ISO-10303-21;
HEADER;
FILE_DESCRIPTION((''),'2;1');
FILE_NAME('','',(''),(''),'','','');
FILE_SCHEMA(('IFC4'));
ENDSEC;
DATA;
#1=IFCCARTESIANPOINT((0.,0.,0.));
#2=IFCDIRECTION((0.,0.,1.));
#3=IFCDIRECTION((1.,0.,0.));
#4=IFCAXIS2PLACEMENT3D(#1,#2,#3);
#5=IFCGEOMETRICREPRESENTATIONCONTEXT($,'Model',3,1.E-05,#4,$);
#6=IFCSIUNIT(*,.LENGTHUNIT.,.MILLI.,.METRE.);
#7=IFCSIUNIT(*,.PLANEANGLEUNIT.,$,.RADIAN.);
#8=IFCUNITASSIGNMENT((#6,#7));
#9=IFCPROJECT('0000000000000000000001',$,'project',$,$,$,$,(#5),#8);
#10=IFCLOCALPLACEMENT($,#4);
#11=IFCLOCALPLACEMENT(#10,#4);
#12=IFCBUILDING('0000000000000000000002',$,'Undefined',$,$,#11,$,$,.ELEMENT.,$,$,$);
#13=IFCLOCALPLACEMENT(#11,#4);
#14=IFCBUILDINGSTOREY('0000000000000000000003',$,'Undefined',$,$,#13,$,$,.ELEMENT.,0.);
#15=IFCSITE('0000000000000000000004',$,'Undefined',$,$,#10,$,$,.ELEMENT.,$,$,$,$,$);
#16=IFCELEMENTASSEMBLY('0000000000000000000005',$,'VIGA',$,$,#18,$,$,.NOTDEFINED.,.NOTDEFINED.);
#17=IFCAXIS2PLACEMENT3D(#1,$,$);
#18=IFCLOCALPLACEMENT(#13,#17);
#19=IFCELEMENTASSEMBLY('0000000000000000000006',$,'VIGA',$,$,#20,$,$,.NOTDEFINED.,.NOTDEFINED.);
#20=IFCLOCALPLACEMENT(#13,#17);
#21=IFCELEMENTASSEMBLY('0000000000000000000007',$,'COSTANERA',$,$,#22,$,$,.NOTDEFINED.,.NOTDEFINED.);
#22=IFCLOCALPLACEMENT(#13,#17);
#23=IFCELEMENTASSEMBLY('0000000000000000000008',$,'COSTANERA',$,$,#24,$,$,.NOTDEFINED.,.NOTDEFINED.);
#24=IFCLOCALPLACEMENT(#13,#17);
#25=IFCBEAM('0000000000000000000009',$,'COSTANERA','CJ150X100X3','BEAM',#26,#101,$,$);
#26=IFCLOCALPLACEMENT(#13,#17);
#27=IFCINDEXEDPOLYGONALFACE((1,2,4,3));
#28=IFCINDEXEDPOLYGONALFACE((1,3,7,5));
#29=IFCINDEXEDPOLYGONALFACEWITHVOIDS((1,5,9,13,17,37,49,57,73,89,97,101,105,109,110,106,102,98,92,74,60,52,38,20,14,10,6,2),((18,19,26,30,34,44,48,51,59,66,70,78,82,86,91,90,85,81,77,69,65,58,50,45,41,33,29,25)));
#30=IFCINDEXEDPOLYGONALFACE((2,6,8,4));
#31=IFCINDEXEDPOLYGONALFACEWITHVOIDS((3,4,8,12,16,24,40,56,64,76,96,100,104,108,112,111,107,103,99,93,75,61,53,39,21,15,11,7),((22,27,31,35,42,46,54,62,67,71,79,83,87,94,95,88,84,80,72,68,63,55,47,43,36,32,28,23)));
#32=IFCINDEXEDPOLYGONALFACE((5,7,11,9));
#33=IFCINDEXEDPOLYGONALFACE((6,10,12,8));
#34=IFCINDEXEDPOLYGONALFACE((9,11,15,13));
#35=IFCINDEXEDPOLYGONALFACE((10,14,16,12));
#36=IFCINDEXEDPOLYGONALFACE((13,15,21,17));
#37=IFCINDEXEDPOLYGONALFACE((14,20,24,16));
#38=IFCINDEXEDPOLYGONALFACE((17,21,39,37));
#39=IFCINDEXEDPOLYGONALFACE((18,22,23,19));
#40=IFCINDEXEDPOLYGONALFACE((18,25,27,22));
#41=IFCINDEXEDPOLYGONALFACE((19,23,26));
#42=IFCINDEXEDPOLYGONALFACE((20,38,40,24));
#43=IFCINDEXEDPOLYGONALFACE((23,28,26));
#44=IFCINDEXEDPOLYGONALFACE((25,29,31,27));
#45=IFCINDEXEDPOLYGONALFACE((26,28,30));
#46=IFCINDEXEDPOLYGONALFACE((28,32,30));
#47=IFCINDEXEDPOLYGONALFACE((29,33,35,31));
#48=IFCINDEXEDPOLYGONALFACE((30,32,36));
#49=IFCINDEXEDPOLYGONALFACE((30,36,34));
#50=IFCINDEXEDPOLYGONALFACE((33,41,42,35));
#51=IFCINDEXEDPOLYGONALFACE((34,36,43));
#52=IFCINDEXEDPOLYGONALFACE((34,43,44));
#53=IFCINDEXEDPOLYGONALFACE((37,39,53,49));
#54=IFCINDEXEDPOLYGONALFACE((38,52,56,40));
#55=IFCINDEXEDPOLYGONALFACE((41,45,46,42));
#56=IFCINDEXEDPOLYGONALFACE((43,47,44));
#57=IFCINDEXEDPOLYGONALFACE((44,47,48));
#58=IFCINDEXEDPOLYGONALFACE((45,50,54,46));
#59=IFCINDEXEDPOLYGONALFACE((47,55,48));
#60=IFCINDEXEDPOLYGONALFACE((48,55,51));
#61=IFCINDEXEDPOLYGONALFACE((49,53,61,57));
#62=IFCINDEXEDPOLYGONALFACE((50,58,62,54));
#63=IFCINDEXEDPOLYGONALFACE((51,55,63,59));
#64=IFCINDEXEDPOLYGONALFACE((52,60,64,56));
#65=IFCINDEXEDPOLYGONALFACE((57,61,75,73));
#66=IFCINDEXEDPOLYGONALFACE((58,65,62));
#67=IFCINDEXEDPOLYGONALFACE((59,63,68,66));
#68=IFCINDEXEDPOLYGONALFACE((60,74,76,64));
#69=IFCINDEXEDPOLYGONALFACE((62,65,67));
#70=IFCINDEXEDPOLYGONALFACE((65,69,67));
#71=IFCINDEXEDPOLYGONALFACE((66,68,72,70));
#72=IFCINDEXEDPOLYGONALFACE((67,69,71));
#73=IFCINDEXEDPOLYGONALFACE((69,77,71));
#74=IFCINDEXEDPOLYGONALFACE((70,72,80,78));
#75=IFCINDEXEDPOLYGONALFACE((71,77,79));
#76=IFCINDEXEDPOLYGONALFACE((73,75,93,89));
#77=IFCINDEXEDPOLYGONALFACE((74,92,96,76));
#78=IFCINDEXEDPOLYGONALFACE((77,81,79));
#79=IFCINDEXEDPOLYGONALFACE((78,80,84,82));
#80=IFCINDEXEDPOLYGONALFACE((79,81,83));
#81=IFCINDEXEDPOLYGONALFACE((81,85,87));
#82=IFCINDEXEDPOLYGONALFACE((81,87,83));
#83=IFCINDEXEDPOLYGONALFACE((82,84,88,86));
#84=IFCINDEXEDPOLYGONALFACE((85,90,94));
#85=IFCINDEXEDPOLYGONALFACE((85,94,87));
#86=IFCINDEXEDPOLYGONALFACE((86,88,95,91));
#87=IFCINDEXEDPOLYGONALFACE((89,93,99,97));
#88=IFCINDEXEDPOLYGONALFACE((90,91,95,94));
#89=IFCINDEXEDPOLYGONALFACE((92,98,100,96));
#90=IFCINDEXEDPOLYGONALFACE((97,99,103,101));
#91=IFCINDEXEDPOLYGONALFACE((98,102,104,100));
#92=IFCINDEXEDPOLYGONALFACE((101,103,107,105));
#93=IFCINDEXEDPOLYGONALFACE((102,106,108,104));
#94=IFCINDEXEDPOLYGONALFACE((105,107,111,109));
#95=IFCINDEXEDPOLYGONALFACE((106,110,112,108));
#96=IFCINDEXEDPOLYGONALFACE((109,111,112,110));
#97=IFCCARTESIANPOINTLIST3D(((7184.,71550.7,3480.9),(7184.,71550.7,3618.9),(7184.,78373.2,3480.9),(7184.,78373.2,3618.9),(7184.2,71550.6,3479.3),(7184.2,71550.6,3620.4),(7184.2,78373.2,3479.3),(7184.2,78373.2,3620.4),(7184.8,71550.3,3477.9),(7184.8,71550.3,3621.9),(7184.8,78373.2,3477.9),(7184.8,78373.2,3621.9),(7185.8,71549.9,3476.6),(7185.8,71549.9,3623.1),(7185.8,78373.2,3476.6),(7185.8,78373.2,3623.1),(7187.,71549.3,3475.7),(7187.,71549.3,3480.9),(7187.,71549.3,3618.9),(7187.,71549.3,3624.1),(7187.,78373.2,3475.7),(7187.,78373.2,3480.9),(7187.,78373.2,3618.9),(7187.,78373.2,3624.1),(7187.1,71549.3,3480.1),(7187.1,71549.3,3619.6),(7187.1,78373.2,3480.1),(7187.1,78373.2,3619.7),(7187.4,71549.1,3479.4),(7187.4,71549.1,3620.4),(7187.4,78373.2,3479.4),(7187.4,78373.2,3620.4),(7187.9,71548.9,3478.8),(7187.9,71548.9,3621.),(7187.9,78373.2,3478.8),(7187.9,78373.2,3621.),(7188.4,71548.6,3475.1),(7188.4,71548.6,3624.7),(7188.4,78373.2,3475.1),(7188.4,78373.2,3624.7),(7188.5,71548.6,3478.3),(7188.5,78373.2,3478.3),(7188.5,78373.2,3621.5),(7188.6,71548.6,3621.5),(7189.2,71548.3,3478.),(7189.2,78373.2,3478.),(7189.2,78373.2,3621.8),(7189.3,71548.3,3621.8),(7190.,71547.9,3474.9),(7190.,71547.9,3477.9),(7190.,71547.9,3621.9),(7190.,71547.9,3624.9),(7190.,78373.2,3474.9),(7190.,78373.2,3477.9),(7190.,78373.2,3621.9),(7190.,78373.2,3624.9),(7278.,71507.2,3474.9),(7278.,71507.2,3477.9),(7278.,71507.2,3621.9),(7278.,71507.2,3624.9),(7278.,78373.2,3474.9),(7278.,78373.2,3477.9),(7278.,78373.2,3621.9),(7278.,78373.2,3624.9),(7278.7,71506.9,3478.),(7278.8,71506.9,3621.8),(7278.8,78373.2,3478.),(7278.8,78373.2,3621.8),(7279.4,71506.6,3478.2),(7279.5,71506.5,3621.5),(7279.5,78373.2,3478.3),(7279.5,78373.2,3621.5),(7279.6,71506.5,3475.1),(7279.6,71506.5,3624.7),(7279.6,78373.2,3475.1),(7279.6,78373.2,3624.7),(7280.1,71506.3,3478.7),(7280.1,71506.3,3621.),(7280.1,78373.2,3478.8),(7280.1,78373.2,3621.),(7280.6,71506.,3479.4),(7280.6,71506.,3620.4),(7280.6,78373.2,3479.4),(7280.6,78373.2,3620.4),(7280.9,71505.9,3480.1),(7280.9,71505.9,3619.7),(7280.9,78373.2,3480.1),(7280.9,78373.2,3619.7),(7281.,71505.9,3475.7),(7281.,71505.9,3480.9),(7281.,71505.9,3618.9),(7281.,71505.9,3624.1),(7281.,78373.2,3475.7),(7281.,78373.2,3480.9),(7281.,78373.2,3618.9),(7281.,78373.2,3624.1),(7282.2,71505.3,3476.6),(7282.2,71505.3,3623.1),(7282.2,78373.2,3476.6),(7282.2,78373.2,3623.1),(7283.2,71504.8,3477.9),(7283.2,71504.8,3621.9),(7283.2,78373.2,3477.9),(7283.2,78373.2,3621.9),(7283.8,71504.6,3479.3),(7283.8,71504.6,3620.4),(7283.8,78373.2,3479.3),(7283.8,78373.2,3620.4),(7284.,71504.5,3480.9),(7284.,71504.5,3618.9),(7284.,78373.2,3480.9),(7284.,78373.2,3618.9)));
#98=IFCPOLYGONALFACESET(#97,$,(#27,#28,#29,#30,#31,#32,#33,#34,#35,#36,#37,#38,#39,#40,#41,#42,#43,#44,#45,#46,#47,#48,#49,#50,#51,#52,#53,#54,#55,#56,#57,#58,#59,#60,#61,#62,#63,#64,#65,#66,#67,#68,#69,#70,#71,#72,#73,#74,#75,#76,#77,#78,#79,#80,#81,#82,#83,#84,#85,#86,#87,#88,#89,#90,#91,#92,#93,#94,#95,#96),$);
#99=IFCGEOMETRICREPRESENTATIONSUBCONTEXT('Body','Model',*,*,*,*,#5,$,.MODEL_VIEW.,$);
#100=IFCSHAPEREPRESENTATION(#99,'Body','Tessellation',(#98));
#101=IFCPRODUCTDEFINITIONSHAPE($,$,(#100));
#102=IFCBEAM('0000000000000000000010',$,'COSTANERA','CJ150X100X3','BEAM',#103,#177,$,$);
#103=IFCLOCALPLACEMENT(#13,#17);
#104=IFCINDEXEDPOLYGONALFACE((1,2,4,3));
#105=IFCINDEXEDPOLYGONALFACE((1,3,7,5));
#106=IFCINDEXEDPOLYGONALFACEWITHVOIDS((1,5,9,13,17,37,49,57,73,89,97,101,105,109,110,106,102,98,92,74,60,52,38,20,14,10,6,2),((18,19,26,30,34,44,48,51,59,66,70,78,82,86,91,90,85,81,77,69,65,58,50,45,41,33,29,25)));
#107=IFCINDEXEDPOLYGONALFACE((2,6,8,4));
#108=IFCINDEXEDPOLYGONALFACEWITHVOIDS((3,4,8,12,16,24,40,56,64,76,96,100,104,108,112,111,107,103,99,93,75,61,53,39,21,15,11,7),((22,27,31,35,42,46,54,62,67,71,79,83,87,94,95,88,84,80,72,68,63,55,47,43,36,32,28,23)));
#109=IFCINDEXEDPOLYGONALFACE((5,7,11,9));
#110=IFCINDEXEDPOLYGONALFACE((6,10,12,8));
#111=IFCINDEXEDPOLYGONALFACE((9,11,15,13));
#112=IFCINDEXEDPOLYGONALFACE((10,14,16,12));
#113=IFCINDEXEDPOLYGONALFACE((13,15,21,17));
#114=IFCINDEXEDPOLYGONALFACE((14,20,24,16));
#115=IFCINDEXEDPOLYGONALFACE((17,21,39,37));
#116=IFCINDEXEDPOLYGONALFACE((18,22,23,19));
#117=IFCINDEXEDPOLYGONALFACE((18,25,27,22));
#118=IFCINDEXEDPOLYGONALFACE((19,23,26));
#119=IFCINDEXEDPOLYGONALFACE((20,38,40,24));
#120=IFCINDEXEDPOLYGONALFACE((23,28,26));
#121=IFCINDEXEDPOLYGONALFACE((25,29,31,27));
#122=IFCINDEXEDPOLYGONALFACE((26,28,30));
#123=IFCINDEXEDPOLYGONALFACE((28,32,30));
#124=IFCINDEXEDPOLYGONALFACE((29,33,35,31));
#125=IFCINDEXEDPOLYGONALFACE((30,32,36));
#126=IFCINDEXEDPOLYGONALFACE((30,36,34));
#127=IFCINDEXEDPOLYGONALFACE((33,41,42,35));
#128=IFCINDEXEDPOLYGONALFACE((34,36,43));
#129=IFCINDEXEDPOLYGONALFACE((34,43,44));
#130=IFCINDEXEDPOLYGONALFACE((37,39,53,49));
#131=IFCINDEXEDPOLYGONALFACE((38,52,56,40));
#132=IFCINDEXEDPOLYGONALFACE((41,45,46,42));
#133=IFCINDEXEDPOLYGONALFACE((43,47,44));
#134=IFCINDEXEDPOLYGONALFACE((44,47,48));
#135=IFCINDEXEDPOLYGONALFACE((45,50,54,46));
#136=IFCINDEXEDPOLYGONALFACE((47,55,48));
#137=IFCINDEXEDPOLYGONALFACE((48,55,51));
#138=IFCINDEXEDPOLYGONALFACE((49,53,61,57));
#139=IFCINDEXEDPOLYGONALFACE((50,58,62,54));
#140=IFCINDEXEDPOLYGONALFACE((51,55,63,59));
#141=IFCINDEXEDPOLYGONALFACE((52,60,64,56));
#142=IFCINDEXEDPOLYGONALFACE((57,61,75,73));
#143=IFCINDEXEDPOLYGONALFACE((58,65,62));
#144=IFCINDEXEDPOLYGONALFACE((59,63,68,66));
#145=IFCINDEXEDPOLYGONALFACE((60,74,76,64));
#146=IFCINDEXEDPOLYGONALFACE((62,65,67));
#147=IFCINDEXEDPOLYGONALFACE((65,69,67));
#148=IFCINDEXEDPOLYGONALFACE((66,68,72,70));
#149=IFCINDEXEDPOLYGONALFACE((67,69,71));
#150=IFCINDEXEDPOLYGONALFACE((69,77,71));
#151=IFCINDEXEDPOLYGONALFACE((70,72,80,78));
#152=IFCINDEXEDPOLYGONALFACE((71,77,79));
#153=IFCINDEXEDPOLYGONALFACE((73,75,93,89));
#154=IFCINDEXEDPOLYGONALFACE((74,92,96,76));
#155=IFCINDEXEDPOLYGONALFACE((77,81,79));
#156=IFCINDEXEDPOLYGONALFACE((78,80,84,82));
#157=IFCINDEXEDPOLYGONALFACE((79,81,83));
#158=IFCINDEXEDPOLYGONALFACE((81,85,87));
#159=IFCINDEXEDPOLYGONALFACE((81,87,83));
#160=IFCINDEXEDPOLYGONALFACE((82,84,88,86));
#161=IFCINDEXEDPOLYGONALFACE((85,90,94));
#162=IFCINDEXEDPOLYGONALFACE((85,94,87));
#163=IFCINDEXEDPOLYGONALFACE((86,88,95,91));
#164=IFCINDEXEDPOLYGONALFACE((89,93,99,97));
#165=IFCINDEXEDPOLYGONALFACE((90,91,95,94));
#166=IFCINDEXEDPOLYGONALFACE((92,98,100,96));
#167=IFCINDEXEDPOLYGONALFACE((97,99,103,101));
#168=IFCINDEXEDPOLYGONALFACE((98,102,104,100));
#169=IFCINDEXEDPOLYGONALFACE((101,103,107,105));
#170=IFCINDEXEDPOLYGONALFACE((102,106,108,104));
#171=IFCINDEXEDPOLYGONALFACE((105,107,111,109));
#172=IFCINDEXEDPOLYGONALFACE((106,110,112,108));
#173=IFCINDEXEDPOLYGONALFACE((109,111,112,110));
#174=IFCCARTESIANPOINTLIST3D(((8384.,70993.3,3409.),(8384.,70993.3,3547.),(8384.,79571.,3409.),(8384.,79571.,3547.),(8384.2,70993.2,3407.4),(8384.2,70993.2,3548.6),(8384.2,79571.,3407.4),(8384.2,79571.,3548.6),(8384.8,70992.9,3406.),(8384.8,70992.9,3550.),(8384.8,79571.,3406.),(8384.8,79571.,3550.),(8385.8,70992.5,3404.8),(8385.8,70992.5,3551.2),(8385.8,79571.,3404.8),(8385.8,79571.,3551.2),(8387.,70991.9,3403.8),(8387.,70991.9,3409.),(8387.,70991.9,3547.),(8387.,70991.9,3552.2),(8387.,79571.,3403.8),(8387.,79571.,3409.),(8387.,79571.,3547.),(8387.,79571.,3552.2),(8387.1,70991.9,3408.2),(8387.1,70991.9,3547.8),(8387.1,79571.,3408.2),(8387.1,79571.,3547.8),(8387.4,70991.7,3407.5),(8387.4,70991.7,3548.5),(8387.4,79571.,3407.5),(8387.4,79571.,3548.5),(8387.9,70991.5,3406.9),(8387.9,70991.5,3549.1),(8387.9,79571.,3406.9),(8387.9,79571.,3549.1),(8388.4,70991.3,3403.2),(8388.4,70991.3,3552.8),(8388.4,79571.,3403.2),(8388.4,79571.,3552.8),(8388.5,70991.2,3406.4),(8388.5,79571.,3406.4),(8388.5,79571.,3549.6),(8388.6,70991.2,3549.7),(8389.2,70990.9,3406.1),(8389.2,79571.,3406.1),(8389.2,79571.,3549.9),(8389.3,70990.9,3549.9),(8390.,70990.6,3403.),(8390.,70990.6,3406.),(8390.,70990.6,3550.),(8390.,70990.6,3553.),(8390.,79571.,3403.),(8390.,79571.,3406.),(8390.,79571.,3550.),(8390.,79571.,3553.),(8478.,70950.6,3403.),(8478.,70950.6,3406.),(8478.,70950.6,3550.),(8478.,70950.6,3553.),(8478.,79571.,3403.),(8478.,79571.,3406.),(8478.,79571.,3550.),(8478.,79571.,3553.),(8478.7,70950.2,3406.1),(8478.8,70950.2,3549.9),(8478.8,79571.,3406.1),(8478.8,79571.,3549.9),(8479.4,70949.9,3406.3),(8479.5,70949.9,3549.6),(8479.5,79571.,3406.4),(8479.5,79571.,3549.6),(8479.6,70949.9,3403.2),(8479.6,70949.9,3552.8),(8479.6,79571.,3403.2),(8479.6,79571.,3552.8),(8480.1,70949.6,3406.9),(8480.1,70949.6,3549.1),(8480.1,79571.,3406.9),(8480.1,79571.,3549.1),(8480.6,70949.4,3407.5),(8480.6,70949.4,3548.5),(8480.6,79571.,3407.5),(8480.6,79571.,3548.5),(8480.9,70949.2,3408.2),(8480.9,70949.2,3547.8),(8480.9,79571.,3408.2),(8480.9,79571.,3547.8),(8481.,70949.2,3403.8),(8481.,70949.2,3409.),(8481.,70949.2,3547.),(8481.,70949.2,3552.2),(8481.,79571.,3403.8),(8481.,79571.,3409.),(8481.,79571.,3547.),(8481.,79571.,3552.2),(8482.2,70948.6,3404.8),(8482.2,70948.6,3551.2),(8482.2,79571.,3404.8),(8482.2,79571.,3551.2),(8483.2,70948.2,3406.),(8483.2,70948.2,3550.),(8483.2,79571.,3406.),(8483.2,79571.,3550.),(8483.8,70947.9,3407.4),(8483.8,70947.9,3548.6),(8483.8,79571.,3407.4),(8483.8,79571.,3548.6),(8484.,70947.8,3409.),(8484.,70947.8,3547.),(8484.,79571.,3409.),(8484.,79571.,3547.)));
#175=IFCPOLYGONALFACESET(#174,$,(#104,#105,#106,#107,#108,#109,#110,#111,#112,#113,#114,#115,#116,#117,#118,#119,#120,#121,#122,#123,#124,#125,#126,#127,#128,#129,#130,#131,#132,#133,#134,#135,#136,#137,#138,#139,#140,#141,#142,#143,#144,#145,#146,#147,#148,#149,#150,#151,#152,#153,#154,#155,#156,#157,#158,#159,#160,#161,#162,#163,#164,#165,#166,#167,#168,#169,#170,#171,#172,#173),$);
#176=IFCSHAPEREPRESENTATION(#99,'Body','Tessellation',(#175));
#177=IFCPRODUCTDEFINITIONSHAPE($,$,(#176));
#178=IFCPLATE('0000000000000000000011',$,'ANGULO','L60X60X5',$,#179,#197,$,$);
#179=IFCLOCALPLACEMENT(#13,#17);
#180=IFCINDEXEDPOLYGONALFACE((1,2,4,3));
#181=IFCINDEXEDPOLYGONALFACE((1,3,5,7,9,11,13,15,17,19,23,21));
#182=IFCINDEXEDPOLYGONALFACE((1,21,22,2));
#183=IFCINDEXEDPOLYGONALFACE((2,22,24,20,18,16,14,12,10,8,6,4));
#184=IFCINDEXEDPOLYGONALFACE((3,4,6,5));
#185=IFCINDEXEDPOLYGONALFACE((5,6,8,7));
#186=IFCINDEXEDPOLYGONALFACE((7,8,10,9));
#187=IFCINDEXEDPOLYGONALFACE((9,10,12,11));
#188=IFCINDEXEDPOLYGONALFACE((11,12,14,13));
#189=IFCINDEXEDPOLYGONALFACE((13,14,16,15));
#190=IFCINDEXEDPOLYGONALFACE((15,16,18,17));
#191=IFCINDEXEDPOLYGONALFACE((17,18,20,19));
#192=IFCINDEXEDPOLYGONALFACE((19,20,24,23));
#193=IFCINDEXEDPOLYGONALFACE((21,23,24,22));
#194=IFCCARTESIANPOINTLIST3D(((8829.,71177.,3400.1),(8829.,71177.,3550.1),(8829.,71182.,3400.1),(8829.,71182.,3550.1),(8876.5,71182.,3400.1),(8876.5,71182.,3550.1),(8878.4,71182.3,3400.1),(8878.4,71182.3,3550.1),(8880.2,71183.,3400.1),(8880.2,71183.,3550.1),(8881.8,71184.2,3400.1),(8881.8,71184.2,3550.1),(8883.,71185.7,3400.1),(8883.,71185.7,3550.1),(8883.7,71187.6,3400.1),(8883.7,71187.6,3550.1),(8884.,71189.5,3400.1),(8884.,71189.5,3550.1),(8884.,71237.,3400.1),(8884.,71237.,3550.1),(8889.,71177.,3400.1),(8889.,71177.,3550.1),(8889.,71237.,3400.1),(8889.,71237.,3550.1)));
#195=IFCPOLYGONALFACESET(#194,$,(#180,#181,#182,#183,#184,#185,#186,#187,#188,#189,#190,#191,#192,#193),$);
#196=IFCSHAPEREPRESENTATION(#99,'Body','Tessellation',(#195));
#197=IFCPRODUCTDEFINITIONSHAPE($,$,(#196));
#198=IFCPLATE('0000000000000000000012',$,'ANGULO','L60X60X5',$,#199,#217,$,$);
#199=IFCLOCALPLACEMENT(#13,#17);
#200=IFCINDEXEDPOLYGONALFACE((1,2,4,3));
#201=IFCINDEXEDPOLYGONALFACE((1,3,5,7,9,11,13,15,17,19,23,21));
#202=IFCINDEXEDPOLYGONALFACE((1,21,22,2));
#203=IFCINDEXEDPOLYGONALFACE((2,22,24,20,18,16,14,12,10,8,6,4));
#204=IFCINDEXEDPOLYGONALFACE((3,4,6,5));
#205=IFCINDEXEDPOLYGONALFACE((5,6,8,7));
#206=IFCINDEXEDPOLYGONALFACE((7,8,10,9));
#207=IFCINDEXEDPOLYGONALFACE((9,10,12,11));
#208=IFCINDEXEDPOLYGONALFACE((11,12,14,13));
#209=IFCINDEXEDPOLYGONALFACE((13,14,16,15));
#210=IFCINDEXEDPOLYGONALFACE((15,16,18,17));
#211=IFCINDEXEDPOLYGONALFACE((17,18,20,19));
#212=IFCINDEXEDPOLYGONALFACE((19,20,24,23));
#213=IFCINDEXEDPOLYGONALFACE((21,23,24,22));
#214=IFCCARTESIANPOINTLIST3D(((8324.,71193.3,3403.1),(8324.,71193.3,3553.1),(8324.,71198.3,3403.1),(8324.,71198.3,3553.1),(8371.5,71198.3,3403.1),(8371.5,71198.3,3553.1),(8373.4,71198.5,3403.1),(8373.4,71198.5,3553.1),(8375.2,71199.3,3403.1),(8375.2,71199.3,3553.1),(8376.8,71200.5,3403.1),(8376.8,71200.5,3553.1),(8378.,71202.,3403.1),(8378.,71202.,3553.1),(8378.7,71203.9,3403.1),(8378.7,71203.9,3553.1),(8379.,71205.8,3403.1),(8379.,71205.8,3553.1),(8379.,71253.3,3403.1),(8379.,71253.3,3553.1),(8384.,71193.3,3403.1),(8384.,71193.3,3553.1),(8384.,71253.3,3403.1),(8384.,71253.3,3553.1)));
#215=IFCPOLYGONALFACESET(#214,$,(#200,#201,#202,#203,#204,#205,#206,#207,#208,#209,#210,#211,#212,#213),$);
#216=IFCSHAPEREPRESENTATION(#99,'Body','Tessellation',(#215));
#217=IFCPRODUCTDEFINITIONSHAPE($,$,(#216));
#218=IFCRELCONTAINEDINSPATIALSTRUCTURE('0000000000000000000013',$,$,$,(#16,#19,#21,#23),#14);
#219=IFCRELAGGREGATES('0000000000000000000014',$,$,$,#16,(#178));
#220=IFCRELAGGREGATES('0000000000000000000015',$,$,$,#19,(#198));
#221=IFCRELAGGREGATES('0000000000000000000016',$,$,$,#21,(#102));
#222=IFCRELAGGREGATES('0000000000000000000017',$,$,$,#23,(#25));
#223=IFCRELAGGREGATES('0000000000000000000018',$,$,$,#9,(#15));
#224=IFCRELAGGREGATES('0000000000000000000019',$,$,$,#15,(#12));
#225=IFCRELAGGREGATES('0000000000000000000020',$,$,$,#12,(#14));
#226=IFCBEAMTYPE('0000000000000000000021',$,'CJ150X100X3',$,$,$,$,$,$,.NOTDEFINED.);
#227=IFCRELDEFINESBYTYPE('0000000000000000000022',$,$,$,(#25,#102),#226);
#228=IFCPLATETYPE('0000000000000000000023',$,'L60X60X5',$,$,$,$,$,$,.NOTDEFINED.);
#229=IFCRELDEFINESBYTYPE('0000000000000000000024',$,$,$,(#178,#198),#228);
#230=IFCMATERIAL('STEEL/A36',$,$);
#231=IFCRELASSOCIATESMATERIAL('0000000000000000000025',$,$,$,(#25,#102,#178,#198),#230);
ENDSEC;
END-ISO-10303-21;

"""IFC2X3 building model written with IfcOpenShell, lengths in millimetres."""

from ifc_helpers import new_model, si_unit, frame, origin_with_axes, origin_2d_with_axis, place, context, subcontext, project, spatial, hollow_rectangle, l_section, extrude, clip, halfspace, material, type_object, element, aggregate, save


model = new_model("IFC2X3")

# Units and contexts
model_context = context("Model", 3, precision=1e-05, world=origin_with_axes())
body_context = subcontext(model_context, "Body", "Model", "MODEL_VIEW")
ifc_project = project(units=[si_unit("LENGTHUNIT", "METRE", prefix="MILLI"), si_unit("PLANEANGLEUNIT", "RADIAN")], contexts=[model_context])

# Site, building, storey
site_placement = place(None, origin_with_axes())
site = spatial("IfcSite", under=ifc_project, at=site_placement, Name="Undefined", CompositionType="ELEMENT")
building_placement = place(site_placement, origin_with_axes())
building = spatial("IfcBuilding", under=site, at=building_placement, Name="Undefined", CompositionType="ELEMENT")
storey_placement = place(building_placement, origin_with_axes())
storey = spatial("IfcBuildingStorey", under=building, at=storey_placement, Name="Undefined", CompositionType="ELEMENT", Elevation=0.0)

# Element assemblies, beam
assembly_1_placement = place(storey_placement, origin_with_axes())
assembly_1 = element("IfcElementAssembly", 1, at=assembly_1_placement, inside=storey, Name="VIGA", AssemblyPlace="NOTDEFINED", PredefinedType="NOTDEFINED")
ifc_material_1 = material(Name="STEEL/A36")
assembly_2_placement = place(storey_placement, origin_with_axes())
assembly_2 = element("IfcElementAssembly", 2, at=assembly_2_placement, inside=storey, Name="VIGA", AssemblyPlace="NOTDEFINED", PredefinedType="NOTDEFINED")
assembly_3_placement = place(storey_placement, origin_with_axes())
assembly_3 = element("IfcElementAssembly", 3, at=assembly_3_placement, inside=storey, Name="COSTANERA", AssemblyPlace="NOTDEFINED", PredefinedType="NOTDEFINED")
beam_type_1 = type_object("IfcBeamType", Name="CJ150X100X3", PredefinedType="NOTDEFINED")
assembly_4_placement = place(storey_placement, origin_with_axes())
assembly_4 = element("IfcElementAssembly", 4, at=assembly_4_placement, inside=storey, Name="COSTANERA", AssemblyPlace="NOTDEFINED", PredefinedType="NOTDEFINED")
beam_1_placement = place(assembly_4_placement, frame((7234.0, 71527.6, 3549.9), z_axis=(0.0, 0.0, 1.0), x_axis=(0.0, 1.0, 0.0)))
beam_1 = element("IfcBeam", 5, at=beam_1_placement, type_object=beam_type_1, material=ifc_material_1, Name="COSTANERA", Description="CJ150X100X3", ObjectType="BEAM", context=body_context, shape_type="Clipping", body=[
    clip(extrude(hollow_rectangle(XDim=100.0, YDim=150.0, WallThickness=3.0, InnerFilletRadius=3.0, OuterFilletRadius=6.0, at=origin_2d_with_axis()), frame((6845.6, 0.0, 0.0), z_axis=(-1.0, 0.0, 0.0), x_axis=(0.0, -1.0, 0.0)), (0.0, 0.0, 1.0), 6868.9), halfspace(frame((-23.1, -50.0, 0.0), z_axis=(0.907705, -0.419608, 0.0), x_axis=(0.0, 0.0, 1.0)), True)),
])

# Beam
beam_2_placement = place(assembly_3_placement, frame((8434.0, 70970.6, 3478.0), z_axis=(0.0, 0.0, 1.0), x_axis=(0.0, 1.0, 0.0)))
beam_2 = element("IfcBeam", 6, at=beam_2_placement, type_object=beam_type_1, material=ifc_material_1, Name="COSTANERA", Description="CJ150X100X3", ObjectType="BEAM", context=body_context, shape_type="Clipping", body=[
    clip(extrude(hollow_rectangle(XDim=100.0, YDim=150.0, WallThickness=3.0, InnerFilletRadius=3.0, OuterFilletRadius=6.0, at=origin_2d_with_axis()), frame((8600.4, 0.0, 0.0), z_axis=(-1.0, 0.0, 0.0), x_axis=(0.0, -1.0, 0.0)), (0.0, 0.0, 1.0), 8623.4), halfspace(frame((-22.7, -50.0, 0.0), z_axis=(0.910337, -0.413868, 0.0), x_axis=(0.0, 0.0, 1.0)), True)),
])

# Plates
plate_type_1 = type_object("IfcPlateType", Name="L60X60X5", PredefinedType="NOTDEFINED")
plate_1_placement = place(assembly_1_placement, frame((8859.0, 71207.0, 3550.1), z_axis=(-1.0, 0.0, 0.0), x_axis=(0.0, 0.0, -1.0)))
plate_1 = element("IfcPlate", 7, at=plate_1_placement, type_object=plate_type_1, material=ifc_material_1, Name="ANGULO", Description="L60X60X5", context=body_context, shape_type="SweptSolid", body=[
    extrude(l_section(Depth=60.0, Width=60.0, Thickness=5.0, FilletRadius=7.5, at=origin_2d_with_axis()), frame((150.0, 0.0, 0.0), z_axis=(-1.0, 0.0, 0.0), x_axis=(0.0, -1.0, 0.0)), (0.0, 0.0, 1.0), 150.0),
])
plate_2_placement = place(assembly_2_placement, frame((8354.0, 71223.3, 3553.1), z_axis=(-1.0, 0.0, 0.0), x_axis=(0.0, 0.0, -1.0)))
plate_2 = element("IfcPlate", 8, at=plate_2_placement, type_object=plate_type_1, material=ifc_material_1, Name="ANGULO", Description="L60X60X5", context=body_context, shape_type="SweptSolid", body=[
    extrude(l_section(Depth=60.0, Width=60.0, Thickness=5.0, FilletRadius=7.5, at=origin_2d_with_axis()), frame((150.0, 0.0, 0.0), z_axis=(-1.0, 0.0, 0.0), x_axis=(0.0, -1.0, 0.0)), (0.0, 0.0, 1.0), 150.0),
])
aggregate(assembly_1, [plate_1])
aggregate(assembly_2, [plate_2])

aggregate(assembly_3, [beam_2])
aggregate(assembly_4, [beam_1])

save(model, "model.ifc")
